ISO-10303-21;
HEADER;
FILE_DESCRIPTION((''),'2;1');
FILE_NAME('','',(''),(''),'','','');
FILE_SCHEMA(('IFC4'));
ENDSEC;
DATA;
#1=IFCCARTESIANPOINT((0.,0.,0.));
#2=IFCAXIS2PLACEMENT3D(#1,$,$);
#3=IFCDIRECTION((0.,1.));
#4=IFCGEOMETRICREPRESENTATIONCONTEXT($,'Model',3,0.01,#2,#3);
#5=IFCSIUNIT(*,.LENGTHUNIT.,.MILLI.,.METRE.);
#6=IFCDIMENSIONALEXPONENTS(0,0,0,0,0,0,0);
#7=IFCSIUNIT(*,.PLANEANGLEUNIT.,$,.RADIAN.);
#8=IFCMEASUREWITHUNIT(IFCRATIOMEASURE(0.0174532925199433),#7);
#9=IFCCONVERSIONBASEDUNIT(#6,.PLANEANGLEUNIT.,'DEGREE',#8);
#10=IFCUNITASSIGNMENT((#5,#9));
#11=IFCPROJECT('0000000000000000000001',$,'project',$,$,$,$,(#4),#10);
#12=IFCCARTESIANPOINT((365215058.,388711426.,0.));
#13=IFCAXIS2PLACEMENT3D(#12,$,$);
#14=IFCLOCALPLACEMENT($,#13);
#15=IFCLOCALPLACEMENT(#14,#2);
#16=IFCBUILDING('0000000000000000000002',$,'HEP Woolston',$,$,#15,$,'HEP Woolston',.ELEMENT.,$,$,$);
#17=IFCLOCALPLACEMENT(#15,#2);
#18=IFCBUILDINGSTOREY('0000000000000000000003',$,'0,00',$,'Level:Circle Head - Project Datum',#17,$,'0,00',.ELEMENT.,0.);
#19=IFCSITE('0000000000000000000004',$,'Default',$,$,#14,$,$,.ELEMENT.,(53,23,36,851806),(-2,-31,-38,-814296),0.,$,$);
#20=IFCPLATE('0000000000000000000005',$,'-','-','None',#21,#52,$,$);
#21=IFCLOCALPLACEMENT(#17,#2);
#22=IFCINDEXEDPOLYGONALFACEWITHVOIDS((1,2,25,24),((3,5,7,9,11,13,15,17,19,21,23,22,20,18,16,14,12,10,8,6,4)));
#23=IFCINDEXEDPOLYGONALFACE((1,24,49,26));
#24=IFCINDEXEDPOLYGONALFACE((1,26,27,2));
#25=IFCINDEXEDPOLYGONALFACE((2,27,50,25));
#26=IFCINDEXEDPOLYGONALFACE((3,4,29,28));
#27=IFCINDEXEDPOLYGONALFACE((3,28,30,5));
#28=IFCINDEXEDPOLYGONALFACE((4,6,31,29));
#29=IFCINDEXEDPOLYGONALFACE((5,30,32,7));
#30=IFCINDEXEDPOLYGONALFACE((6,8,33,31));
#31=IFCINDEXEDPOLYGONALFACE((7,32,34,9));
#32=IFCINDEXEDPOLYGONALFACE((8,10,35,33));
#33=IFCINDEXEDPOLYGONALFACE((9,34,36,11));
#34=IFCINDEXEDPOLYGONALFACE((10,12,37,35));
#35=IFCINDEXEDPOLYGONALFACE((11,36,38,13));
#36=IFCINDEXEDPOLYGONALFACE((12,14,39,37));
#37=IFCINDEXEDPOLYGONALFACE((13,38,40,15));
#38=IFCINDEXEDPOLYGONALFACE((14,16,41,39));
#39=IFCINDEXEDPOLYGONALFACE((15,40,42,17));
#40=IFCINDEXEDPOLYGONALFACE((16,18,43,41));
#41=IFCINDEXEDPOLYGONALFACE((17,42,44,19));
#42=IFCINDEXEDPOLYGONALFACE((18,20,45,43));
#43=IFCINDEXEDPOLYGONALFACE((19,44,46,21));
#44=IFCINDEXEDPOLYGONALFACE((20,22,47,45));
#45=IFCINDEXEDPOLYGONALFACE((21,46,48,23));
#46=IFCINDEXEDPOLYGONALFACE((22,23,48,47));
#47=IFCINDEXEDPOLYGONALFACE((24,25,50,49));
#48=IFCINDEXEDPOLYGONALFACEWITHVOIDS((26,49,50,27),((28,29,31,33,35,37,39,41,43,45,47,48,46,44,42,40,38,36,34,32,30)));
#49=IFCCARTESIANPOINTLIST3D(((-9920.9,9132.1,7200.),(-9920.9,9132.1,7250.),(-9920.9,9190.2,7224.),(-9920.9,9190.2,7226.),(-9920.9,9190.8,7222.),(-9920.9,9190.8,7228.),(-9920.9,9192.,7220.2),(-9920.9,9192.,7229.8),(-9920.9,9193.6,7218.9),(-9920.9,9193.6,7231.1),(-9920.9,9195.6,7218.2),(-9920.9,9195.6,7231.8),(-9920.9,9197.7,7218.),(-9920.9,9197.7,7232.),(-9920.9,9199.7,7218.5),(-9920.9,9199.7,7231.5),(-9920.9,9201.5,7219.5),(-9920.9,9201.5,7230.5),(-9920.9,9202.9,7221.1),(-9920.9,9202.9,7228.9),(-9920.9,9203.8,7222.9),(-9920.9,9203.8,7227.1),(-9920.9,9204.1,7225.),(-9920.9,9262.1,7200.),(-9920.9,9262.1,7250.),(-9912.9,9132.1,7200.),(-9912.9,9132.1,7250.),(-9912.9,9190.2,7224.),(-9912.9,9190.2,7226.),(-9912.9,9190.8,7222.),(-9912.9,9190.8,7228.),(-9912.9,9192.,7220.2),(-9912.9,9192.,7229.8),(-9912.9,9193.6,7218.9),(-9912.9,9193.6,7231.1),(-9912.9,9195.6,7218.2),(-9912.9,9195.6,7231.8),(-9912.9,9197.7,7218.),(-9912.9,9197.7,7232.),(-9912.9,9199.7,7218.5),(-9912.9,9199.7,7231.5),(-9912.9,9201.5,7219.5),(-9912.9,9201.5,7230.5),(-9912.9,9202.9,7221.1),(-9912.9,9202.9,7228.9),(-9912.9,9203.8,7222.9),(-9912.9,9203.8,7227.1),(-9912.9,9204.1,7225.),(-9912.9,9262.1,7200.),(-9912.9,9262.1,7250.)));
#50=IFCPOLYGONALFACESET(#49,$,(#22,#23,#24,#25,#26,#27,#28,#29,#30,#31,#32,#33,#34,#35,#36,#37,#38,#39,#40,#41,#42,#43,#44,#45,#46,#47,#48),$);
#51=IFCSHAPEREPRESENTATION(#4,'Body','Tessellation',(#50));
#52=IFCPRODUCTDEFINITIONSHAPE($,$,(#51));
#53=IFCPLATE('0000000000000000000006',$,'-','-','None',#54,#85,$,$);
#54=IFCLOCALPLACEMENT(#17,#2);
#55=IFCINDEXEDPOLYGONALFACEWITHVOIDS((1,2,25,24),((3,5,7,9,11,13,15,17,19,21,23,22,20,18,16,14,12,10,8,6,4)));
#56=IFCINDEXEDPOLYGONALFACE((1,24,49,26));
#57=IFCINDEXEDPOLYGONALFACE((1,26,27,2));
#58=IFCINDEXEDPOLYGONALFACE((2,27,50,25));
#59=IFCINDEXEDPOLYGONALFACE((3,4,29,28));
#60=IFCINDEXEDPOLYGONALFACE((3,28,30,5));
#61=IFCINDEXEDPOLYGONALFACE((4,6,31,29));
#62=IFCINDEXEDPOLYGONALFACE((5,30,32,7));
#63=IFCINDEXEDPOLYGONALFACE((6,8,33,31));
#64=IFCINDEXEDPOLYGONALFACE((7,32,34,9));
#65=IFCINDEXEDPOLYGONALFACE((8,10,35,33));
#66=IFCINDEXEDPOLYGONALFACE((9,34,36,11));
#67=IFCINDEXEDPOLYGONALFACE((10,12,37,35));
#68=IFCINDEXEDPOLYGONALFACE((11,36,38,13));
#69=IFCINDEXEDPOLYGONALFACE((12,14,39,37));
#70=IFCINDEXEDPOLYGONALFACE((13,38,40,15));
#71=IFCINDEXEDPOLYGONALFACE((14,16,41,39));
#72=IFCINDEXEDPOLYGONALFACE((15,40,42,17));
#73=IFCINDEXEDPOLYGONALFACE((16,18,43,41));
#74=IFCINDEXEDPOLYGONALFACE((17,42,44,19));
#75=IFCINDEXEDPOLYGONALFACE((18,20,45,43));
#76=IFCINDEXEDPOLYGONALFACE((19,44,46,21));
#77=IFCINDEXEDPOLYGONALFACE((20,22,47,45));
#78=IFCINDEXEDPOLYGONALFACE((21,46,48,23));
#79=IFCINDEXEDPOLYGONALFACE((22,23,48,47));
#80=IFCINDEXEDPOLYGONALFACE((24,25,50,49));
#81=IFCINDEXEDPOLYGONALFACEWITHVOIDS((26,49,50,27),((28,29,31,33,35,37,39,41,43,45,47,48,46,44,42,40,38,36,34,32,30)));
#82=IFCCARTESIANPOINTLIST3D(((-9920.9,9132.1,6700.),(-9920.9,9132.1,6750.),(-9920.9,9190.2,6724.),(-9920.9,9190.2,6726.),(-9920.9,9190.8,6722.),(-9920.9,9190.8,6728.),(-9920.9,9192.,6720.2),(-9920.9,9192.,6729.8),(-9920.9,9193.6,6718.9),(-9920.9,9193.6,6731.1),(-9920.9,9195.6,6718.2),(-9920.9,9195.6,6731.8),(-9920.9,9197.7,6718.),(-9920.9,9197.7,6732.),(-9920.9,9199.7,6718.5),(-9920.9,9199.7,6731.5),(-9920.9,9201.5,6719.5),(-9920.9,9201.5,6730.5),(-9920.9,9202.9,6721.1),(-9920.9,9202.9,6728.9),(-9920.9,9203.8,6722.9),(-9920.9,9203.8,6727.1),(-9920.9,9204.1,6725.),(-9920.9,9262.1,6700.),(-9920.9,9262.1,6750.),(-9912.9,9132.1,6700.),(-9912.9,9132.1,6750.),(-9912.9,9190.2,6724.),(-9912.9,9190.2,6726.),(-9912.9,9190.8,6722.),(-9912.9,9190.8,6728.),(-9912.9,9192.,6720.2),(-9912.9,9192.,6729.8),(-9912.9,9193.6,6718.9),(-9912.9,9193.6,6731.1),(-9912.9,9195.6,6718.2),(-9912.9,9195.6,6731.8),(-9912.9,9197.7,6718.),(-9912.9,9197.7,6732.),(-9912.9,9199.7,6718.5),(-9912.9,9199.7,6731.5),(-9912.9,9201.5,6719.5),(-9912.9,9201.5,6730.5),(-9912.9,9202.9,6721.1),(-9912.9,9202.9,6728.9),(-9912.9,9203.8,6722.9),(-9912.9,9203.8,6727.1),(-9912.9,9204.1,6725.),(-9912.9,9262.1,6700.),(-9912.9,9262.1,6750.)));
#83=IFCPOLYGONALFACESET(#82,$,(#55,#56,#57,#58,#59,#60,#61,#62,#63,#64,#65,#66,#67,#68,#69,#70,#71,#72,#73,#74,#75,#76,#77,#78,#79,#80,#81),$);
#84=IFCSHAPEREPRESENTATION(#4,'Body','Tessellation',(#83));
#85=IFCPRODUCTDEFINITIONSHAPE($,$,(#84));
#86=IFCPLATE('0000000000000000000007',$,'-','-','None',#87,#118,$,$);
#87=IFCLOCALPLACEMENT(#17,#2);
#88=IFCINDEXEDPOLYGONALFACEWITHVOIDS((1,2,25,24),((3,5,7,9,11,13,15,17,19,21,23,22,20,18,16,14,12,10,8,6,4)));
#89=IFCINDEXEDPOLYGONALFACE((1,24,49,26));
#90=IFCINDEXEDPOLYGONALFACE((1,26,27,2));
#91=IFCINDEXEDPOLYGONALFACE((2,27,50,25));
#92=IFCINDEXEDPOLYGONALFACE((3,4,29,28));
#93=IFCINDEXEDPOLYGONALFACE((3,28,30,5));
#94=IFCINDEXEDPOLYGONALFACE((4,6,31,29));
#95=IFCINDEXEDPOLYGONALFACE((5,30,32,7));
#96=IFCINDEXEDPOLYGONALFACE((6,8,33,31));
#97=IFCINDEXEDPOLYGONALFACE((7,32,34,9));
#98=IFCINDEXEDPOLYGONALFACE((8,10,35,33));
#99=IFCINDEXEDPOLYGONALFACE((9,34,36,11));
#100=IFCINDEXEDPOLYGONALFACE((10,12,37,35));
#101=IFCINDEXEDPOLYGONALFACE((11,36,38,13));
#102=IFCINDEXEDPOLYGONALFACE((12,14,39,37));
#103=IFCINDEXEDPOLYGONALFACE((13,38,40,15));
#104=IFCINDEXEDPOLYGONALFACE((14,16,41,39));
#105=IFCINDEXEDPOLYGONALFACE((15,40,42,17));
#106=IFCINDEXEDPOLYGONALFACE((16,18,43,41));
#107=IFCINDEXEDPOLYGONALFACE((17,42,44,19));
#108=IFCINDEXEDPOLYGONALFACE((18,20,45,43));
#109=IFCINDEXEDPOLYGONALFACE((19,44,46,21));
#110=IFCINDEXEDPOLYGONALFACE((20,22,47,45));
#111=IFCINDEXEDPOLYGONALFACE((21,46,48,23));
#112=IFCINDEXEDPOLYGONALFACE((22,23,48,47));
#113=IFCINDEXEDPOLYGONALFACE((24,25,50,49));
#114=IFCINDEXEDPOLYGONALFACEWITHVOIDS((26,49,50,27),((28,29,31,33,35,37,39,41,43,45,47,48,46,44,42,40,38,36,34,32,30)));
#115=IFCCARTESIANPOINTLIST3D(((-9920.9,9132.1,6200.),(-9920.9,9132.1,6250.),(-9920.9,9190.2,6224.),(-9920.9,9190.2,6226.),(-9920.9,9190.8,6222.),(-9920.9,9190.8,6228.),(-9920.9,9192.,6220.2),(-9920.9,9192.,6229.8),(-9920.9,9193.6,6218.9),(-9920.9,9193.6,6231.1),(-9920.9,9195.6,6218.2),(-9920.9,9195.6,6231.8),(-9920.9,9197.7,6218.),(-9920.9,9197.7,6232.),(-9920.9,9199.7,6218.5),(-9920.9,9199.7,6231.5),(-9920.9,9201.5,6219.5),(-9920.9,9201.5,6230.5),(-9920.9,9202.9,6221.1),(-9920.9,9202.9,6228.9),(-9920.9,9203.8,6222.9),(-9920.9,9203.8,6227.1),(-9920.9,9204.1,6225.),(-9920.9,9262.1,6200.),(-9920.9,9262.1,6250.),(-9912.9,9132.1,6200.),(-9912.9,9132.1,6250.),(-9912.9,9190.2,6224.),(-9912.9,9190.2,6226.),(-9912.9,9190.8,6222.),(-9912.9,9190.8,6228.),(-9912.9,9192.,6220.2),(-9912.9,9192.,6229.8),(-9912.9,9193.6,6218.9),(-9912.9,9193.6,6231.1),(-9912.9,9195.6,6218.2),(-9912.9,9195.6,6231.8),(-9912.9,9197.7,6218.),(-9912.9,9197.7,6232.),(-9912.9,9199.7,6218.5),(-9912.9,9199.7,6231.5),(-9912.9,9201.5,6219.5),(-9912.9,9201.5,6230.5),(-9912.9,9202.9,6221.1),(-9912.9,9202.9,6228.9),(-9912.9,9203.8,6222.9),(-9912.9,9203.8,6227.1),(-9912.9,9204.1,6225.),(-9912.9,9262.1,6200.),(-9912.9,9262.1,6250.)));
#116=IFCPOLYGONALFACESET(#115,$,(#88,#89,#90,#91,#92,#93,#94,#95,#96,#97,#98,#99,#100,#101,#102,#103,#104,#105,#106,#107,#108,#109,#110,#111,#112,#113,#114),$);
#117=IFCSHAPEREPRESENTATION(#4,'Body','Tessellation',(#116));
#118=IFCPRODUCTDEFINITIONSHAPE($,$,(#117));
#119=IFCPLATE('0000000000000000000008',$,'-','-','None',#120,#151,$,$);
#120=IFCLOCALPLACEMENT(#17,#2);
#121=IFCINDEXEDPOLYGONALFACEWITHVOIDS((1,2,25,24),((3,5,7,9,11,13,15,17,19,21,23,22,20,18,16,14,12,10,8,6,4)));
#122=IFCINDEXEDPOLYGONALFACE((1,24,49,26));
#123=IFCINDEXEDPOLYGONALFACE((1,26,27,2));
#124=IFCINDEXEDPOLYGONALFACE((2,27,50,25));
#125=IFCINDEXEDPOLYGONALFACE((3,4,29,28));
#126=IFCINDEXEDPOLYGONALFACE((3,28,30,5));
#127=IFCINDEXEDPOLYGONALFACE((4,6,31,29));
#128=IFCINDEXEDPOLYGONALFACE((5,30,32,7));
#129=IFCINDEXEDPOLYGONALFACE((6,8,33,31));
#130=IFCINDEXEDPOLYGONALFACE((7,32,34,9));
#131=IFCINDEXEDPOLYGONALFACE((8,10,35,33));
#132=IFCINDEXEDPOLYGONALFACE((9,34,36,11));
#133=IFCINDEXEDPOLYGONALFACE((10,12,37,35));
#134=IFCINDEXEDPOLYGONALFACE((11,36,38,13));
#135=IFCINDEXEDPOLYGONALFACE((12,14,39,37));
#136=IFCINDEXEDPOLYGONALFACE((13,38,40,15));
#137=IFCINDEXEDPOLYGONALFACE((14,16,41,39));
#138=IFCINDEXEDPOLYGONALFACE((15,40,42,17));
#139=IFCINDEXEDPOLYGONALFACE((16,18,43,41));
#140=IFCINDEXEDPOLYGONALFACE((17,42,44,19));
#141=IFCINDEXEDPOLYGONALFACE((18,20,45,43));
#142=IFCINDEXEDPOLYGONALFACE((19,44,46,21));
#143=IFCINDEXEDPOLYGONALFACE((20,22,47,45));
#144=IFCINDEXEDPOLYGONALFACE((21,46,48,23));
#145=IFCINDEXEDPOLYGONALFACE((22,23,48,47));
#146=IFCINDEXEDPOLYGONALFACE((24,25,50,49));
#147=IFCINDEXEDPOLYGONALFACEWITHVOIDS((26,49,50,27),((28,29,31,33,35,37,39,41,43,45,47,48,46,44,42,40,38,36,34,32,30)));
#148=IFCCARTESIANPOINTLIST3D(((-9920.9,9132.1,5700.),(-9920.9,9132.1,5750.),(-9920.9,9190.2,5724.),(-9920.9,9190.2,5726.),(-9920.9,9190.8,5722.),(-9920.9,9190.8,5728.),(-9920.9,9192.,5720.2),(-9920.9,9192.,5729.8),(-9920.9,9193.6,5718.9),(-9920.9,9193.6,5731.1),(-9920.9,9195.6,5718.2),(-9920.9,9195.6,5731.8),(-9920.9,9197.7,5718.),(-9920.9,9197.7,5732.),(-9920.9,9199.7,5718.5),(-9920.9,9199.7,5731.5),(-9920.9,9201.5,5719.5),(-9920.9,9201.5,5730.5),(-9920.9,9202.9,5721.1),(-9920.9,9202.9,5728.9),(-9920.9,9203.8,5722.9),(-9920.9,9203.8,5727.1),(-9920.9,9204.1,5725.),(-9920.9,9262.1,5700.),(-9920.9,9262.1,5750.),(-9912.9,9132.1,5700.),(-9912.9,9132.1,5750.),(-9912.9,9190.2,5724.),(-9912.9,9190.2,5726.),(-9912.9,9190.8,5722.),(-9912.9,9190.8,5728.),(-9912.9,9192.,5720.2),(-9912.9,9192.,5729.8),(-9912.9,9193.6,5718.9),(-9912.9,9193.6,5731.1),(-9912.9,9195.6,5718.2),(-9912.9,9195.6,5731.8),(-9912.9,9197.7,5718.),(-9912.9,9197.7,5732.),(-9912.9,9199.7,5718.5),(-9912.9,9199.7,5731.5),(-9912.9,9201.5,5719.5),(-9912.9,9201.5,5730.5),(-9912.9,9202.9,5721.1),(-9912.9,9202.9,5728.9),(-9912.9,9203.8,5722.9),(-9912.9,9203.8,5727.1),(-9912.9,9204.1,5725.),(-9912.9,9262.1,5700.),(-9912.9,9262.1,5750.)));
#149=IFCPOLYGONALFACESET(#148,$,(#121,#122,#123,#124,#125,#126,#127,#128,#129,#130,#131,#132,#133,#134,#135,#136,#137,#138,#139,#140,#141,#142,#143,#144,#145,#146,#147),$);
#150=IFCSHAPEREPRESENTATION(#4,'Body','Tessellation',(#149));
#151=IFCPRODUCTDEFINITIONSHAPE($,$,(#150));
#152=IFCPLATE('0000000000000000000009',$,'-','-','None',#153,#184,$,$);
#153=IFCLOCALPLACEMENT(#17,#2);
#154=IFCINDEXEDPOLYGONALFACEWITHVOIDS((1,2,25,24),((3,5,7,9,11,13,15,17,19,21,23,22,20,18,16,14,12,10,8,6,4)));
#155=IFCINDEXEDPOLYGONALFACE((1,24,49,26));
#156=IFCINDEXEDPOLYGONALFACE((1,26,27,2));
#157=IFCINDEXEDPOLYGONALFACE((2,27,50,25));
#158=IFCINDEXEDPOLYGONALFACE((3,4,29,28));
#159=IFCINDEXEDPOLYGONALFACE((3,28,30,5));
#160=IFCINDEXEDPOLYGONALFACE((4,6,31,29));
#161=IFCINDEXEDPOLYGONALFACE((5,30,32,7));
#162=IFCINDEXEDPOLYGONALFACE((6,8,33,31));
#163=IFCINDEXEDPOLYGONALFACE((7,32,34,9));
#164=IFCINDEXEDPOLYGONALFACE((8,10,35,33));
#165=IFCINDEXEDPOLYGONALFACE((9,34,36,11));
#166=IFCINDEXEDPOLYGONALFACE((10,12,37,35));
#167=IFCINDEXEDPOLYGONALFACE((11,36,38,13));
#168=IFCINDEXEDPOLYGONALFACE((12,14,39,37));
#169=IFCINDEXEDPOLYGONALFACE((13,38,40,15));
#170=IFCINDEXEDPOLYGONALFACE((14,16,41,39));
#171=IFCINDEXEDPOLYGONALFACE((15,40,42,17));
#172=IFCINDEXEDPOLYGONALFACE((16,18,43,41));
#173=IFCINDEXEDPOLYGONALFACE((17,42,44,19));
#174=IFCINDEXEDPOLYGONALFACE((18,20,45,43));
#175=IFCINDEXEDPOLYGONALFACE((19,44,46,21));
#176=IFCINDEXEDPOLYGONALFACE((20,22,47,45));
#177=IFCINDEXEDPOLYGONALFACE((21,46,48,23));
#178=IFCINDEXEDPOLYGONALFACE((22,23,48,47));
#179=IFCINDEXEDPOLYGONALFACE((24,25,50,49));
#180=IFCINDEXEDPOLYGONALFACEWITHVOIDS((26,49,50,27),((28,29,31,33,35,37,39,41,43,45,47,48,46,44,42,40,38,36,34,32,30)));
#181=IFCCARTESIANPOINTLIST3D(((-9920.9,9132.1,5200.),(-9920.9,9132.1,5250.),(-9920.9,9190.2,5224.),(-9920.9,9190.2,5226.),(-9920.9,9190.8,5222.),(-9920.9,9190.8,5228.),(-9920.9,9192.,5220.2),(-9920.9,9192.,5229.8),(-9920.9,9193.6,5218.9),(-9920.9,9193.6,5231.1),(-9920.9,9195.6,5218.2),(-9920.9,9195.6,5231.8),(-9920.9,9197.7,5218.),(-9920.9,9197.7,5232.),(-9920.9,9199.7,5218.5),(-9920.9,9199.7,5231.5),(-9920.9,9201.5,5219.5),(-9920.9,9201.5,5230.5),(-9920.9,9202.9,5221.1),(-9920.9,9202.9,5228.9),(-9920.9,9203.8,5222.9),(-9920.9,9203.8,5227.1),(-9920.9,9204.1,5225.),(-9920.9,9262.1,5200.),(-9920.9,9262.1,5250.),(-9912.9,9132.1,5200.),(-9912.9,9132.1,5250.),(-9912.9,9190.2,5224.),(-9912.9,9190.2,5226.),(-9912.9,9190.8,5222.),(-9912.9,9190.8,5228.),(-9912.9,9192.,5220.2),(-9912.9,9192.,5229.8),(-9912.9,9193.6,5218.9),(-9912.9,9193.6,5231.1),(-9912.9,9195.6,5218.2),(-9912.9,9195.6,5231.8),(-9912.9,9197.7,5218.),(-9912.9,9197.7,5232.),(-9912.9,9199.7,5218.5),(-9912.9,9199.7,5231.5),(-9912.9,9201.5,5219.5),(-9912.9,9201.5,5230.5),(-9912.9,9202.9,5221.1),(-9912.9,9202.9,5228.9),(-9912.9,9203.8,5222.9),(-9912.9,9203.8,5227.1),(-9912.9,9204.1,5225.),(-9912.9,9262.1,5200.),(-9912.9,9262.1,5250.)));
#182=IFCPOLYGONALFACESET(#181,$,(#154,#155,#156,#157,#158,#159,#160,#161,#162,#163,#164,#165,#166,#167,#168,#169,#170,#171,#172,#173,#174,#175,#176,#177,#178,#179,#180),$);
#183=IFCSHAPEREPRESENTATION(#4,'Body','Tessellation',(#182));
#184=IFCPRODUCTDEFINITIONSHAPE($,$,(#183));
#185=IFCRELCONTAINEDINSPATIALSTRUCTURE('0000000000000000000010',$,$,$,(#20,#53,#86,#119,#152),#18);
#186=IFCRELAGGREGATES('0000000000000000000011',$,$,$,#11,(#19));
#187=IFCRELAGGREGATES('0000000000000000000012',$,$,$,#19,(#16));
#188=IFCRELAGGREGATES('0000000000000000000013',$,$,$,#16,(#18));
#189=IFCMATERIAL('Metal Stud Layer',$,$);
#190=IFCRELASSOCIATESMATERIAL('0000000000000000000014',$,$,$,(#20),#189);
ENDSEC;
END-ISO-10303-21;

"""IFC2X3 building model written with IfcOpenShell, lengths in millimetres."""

from ifc_helpers import new_model, entity, si_unit, converted_unit, direction, frame, origin, origin_with_axes, origin_2d_with_axis, place, context, project, spatial, polyline, circle, outline, extrude, material, element, save


model = new_model("IFC2X3")

# Units and contexts
model_context = context("Model", 3, precision=0.01, world=origin(), true_north=direction((0.0, 1.0)))
ifc_project = project(units=[si_unit("LENGTHUNIT", "METRE", prefix="MILLI"), converted_unit("PLANEANGLEUNIT", "DEGREE", entity("IfcRatioMeasure", 0.0174532925199433), si_unit("PLANEANGLEUNIT", "RADIAN"), dimensions=[0, 0, 0, 0, 0, 0, 0])], contexts=[model_context])

# Site, building, storey
site_placement = place(None, frame((365215058.0, 388711426.0, 0.0)))
site = spatial("IfcSite", under=ifc_project, at=site_placement, Name="Default", CompositionType="ELEMENT", RefLatitude=(53, 23, 36, 851806), RefLongitude=(-2, -31, -38, -814296), RefElevation=0.0)
building_placement = place(site_placement, origin())
building = spatial("IfcBuilding", under=site, at=building_placement, Name="HEP Woolston", LongName="HEP Woolston", CompositionType="ELEMENT")
storey_placement = place(building_placement, origin())
storey = spatial("IfcBuildingStorey", under=building, at=storey_placement, Name="0,00", ObjectType="Level:Circle Head - Project Datum", LongName="0,00", CompositionType="ELEMENT", Elevation=0.0)

# Plates, openings
ifc_material = material(Name="Metal Stud Layer")
plate_1_placement = place(storey_placement, frame((-9920.9, 9132.1, 7250.0), z_axis=(1.0, 0.0, 0.0), x_axis=(0.0, 1.0, 0.0)))
plate_1 = element("IfcPlate", 1, at=plate_1_placement, inside=storey, material=ifc_material, Name="-", Description="-", ObjectType="None", context=model_context, shape_type="SweptSolid", body=[
    extrude(outline(polyline([(0.0, -50.0), (130.0, -50.0), (130.0, 0.0), (0.0, 0.0), (0.0, -50.0)])), origin_with_axes(), (0.0, 0.0, 1.0), 8.0),
])
opening_1_placement = place(plate_1_placement, frame((65.0, -25.0, 8.5), z_axis=(0.0, 0.0, -1.0), x_axis=(1.0, 0.0, 0.0)))
element("IfcOpeningElement", 2, at=opening_1_placement, cuts=plate_1, ObjectType="Opening", context=model_context, shape_type="SweptSolid", body=[
    extrude(circle(Radius=7.0, at=origin_2d_with_axis()), origin(), (0.0, 0.0, 1.0), 9.0),
])
plate_2_placement = place(storey_placement, frame((-9920.9, 9132.1, 6750.0), z_axis=(1.0, 0.0, 0.0), x_axis=(0.0, 1.0, 0.0)))
plate_2 = element("IfcPlate", 3, at=plate_2_placement, inside=storey, Name="-", Description="-", ObjectType="None", context=model_context, shape_type="SweptSolid", body=[
    extrude(outline(polyline([(0.0, -50.0), (130.0, -50.0), (130.0, 0.0), (0.0, 0.0), (0.0, -50.0)])), origin_with_axes(), (0.0, 0.0, 1.0), 8.0),
])
opening_2_placement = place(plate_2_placement, frame((65.0, -25.0, 8.5), z_axis=(0.0, 0.0, -1.0), x_axis=(1.0, 0.0, 0.0)))
element("IfcOpeningElement", 4, at=opening_2_placement, cuts=plate_2, ObjectType="Opening", context=model_context, shape_type="SweptSolid", body=[
    extrude(circle(Radius=7.0, at=origin_2d_with_axis()), origin(), (0.0, 0.0, 1.0), 9.0),
])
plate_3_placement = place(storey_placement, frame((-9920.9, 9132.1, 6250.0), z_axis=(1.0, 0.0, 0.0), x_axis=(0.0, 1.0, 0.0)))
plate_3 = element("IfcPlate", 5, at=plate_3_placement, inside=storey, Name="-", Description="-", ObjectType="None", context=model_context, shape_type="SweptSolid", body=[
    extrude(outline(polyline([(0.0, -50.0), (130.0, -50.0), (130.0, 0.0), (0.0, 0.0), (0.0, -50.0)])), origin_with_axes(), (0.0, 0.0, 1.0), 8.0),
])
opening_3_placement = place(plate_3_placement, frame((65.0, -25.0, 8.5), z_axis=(0.0, 0.0, -1.0), x_axis=(1.0, 0.0, 0.0)))
element("IfcOpeningElement", 6, at=opening_3_placement, cuts=plate_3, ObjectType="Opening", context=model_context, shape_type="SweptSolid", body=[
    extrude(circle(Radius=7.0, at=origin_2d_with_axis()), origin(), (0.0, 0.0, 1.0), 9.0),
])
plate_4_placement = place(storey_placement, frame((-9920.9, 9132.1, 5750.0), z_axis=(1.0, 0.0, 0.0), x_axis=(0.0, 1.0, 0.0)))
plate_4 = element("IfcPlate", 7, at=plate_4_placement, inside=storey, Name="-", Description="-", ObjectType="None", context=model_context, shape_type="SweptSolid", body=[
    extrude(outline(polyline([(0.0, -50.0), (130.0, -50.0), (130.0, 0.0), (0.0, 0.0), (0.0, -50.0)])), origin_with_axes(), (0.0, 0.0, 1.0), 8.0),
])
opening_4_placement = place(plate_4_placement, frame((65.0, -25.0, 8.5), z_axis=(0.0, 0.0, -1.0), x_axis=(1.0, 0.0, 0.0)))
element("IfcOpeningElement", 8, at=opening_4_placement, cuts=plate_4, ObjectType="Opening", context=model_context, shape_type="SweptSolid", body=[
    extrude(circle(Radius=7.0, at=origin_2d_with_axis()), origin(), (0.0, 0.0, 1.0), 9.0),
])
plate_5_placement = place(storey_placement, frame((-9920.9, 9132.1, 5250.0), z_axis=(1.0, 0.0, 0.0), x_axis=(0.0, 1.0, 0.0)))
plate_5 = element("IfcPlate", 9, at=plate_5_placement, inside=storey, Name="-", Description="-", ObjectType="None", context=model_context, shape_type="SweptSolid", body=[
    extrude(outline(polyline([(0.0, -50.0), (130.0, -50.0), (130.0, 0.0), (0.0, 0.0), (0.0, -50.0)])), origin_with_axes(), (0.0, 0.0, 1.0), 8.0),
])
opening_5_placement = place(plate_5_placement, frame((65.0, -25.0, 8.5), z_axis=(0.0, 0.0, -1.0), x_axis=(1.0, 0.0, 0.0)))
element("IfcOpeningElement", 10, at=opening_5_placement, cuts=plate_5, ObjectType="Opening", context=model_context, shape_type="SweptSolid", body=[
    extrude(circle(Radius=7.0, at=origin_2d_with_axis()), origin(), (0.0, 0.0, 1.0), 9.0),
])

save(model, "model.ifc")
